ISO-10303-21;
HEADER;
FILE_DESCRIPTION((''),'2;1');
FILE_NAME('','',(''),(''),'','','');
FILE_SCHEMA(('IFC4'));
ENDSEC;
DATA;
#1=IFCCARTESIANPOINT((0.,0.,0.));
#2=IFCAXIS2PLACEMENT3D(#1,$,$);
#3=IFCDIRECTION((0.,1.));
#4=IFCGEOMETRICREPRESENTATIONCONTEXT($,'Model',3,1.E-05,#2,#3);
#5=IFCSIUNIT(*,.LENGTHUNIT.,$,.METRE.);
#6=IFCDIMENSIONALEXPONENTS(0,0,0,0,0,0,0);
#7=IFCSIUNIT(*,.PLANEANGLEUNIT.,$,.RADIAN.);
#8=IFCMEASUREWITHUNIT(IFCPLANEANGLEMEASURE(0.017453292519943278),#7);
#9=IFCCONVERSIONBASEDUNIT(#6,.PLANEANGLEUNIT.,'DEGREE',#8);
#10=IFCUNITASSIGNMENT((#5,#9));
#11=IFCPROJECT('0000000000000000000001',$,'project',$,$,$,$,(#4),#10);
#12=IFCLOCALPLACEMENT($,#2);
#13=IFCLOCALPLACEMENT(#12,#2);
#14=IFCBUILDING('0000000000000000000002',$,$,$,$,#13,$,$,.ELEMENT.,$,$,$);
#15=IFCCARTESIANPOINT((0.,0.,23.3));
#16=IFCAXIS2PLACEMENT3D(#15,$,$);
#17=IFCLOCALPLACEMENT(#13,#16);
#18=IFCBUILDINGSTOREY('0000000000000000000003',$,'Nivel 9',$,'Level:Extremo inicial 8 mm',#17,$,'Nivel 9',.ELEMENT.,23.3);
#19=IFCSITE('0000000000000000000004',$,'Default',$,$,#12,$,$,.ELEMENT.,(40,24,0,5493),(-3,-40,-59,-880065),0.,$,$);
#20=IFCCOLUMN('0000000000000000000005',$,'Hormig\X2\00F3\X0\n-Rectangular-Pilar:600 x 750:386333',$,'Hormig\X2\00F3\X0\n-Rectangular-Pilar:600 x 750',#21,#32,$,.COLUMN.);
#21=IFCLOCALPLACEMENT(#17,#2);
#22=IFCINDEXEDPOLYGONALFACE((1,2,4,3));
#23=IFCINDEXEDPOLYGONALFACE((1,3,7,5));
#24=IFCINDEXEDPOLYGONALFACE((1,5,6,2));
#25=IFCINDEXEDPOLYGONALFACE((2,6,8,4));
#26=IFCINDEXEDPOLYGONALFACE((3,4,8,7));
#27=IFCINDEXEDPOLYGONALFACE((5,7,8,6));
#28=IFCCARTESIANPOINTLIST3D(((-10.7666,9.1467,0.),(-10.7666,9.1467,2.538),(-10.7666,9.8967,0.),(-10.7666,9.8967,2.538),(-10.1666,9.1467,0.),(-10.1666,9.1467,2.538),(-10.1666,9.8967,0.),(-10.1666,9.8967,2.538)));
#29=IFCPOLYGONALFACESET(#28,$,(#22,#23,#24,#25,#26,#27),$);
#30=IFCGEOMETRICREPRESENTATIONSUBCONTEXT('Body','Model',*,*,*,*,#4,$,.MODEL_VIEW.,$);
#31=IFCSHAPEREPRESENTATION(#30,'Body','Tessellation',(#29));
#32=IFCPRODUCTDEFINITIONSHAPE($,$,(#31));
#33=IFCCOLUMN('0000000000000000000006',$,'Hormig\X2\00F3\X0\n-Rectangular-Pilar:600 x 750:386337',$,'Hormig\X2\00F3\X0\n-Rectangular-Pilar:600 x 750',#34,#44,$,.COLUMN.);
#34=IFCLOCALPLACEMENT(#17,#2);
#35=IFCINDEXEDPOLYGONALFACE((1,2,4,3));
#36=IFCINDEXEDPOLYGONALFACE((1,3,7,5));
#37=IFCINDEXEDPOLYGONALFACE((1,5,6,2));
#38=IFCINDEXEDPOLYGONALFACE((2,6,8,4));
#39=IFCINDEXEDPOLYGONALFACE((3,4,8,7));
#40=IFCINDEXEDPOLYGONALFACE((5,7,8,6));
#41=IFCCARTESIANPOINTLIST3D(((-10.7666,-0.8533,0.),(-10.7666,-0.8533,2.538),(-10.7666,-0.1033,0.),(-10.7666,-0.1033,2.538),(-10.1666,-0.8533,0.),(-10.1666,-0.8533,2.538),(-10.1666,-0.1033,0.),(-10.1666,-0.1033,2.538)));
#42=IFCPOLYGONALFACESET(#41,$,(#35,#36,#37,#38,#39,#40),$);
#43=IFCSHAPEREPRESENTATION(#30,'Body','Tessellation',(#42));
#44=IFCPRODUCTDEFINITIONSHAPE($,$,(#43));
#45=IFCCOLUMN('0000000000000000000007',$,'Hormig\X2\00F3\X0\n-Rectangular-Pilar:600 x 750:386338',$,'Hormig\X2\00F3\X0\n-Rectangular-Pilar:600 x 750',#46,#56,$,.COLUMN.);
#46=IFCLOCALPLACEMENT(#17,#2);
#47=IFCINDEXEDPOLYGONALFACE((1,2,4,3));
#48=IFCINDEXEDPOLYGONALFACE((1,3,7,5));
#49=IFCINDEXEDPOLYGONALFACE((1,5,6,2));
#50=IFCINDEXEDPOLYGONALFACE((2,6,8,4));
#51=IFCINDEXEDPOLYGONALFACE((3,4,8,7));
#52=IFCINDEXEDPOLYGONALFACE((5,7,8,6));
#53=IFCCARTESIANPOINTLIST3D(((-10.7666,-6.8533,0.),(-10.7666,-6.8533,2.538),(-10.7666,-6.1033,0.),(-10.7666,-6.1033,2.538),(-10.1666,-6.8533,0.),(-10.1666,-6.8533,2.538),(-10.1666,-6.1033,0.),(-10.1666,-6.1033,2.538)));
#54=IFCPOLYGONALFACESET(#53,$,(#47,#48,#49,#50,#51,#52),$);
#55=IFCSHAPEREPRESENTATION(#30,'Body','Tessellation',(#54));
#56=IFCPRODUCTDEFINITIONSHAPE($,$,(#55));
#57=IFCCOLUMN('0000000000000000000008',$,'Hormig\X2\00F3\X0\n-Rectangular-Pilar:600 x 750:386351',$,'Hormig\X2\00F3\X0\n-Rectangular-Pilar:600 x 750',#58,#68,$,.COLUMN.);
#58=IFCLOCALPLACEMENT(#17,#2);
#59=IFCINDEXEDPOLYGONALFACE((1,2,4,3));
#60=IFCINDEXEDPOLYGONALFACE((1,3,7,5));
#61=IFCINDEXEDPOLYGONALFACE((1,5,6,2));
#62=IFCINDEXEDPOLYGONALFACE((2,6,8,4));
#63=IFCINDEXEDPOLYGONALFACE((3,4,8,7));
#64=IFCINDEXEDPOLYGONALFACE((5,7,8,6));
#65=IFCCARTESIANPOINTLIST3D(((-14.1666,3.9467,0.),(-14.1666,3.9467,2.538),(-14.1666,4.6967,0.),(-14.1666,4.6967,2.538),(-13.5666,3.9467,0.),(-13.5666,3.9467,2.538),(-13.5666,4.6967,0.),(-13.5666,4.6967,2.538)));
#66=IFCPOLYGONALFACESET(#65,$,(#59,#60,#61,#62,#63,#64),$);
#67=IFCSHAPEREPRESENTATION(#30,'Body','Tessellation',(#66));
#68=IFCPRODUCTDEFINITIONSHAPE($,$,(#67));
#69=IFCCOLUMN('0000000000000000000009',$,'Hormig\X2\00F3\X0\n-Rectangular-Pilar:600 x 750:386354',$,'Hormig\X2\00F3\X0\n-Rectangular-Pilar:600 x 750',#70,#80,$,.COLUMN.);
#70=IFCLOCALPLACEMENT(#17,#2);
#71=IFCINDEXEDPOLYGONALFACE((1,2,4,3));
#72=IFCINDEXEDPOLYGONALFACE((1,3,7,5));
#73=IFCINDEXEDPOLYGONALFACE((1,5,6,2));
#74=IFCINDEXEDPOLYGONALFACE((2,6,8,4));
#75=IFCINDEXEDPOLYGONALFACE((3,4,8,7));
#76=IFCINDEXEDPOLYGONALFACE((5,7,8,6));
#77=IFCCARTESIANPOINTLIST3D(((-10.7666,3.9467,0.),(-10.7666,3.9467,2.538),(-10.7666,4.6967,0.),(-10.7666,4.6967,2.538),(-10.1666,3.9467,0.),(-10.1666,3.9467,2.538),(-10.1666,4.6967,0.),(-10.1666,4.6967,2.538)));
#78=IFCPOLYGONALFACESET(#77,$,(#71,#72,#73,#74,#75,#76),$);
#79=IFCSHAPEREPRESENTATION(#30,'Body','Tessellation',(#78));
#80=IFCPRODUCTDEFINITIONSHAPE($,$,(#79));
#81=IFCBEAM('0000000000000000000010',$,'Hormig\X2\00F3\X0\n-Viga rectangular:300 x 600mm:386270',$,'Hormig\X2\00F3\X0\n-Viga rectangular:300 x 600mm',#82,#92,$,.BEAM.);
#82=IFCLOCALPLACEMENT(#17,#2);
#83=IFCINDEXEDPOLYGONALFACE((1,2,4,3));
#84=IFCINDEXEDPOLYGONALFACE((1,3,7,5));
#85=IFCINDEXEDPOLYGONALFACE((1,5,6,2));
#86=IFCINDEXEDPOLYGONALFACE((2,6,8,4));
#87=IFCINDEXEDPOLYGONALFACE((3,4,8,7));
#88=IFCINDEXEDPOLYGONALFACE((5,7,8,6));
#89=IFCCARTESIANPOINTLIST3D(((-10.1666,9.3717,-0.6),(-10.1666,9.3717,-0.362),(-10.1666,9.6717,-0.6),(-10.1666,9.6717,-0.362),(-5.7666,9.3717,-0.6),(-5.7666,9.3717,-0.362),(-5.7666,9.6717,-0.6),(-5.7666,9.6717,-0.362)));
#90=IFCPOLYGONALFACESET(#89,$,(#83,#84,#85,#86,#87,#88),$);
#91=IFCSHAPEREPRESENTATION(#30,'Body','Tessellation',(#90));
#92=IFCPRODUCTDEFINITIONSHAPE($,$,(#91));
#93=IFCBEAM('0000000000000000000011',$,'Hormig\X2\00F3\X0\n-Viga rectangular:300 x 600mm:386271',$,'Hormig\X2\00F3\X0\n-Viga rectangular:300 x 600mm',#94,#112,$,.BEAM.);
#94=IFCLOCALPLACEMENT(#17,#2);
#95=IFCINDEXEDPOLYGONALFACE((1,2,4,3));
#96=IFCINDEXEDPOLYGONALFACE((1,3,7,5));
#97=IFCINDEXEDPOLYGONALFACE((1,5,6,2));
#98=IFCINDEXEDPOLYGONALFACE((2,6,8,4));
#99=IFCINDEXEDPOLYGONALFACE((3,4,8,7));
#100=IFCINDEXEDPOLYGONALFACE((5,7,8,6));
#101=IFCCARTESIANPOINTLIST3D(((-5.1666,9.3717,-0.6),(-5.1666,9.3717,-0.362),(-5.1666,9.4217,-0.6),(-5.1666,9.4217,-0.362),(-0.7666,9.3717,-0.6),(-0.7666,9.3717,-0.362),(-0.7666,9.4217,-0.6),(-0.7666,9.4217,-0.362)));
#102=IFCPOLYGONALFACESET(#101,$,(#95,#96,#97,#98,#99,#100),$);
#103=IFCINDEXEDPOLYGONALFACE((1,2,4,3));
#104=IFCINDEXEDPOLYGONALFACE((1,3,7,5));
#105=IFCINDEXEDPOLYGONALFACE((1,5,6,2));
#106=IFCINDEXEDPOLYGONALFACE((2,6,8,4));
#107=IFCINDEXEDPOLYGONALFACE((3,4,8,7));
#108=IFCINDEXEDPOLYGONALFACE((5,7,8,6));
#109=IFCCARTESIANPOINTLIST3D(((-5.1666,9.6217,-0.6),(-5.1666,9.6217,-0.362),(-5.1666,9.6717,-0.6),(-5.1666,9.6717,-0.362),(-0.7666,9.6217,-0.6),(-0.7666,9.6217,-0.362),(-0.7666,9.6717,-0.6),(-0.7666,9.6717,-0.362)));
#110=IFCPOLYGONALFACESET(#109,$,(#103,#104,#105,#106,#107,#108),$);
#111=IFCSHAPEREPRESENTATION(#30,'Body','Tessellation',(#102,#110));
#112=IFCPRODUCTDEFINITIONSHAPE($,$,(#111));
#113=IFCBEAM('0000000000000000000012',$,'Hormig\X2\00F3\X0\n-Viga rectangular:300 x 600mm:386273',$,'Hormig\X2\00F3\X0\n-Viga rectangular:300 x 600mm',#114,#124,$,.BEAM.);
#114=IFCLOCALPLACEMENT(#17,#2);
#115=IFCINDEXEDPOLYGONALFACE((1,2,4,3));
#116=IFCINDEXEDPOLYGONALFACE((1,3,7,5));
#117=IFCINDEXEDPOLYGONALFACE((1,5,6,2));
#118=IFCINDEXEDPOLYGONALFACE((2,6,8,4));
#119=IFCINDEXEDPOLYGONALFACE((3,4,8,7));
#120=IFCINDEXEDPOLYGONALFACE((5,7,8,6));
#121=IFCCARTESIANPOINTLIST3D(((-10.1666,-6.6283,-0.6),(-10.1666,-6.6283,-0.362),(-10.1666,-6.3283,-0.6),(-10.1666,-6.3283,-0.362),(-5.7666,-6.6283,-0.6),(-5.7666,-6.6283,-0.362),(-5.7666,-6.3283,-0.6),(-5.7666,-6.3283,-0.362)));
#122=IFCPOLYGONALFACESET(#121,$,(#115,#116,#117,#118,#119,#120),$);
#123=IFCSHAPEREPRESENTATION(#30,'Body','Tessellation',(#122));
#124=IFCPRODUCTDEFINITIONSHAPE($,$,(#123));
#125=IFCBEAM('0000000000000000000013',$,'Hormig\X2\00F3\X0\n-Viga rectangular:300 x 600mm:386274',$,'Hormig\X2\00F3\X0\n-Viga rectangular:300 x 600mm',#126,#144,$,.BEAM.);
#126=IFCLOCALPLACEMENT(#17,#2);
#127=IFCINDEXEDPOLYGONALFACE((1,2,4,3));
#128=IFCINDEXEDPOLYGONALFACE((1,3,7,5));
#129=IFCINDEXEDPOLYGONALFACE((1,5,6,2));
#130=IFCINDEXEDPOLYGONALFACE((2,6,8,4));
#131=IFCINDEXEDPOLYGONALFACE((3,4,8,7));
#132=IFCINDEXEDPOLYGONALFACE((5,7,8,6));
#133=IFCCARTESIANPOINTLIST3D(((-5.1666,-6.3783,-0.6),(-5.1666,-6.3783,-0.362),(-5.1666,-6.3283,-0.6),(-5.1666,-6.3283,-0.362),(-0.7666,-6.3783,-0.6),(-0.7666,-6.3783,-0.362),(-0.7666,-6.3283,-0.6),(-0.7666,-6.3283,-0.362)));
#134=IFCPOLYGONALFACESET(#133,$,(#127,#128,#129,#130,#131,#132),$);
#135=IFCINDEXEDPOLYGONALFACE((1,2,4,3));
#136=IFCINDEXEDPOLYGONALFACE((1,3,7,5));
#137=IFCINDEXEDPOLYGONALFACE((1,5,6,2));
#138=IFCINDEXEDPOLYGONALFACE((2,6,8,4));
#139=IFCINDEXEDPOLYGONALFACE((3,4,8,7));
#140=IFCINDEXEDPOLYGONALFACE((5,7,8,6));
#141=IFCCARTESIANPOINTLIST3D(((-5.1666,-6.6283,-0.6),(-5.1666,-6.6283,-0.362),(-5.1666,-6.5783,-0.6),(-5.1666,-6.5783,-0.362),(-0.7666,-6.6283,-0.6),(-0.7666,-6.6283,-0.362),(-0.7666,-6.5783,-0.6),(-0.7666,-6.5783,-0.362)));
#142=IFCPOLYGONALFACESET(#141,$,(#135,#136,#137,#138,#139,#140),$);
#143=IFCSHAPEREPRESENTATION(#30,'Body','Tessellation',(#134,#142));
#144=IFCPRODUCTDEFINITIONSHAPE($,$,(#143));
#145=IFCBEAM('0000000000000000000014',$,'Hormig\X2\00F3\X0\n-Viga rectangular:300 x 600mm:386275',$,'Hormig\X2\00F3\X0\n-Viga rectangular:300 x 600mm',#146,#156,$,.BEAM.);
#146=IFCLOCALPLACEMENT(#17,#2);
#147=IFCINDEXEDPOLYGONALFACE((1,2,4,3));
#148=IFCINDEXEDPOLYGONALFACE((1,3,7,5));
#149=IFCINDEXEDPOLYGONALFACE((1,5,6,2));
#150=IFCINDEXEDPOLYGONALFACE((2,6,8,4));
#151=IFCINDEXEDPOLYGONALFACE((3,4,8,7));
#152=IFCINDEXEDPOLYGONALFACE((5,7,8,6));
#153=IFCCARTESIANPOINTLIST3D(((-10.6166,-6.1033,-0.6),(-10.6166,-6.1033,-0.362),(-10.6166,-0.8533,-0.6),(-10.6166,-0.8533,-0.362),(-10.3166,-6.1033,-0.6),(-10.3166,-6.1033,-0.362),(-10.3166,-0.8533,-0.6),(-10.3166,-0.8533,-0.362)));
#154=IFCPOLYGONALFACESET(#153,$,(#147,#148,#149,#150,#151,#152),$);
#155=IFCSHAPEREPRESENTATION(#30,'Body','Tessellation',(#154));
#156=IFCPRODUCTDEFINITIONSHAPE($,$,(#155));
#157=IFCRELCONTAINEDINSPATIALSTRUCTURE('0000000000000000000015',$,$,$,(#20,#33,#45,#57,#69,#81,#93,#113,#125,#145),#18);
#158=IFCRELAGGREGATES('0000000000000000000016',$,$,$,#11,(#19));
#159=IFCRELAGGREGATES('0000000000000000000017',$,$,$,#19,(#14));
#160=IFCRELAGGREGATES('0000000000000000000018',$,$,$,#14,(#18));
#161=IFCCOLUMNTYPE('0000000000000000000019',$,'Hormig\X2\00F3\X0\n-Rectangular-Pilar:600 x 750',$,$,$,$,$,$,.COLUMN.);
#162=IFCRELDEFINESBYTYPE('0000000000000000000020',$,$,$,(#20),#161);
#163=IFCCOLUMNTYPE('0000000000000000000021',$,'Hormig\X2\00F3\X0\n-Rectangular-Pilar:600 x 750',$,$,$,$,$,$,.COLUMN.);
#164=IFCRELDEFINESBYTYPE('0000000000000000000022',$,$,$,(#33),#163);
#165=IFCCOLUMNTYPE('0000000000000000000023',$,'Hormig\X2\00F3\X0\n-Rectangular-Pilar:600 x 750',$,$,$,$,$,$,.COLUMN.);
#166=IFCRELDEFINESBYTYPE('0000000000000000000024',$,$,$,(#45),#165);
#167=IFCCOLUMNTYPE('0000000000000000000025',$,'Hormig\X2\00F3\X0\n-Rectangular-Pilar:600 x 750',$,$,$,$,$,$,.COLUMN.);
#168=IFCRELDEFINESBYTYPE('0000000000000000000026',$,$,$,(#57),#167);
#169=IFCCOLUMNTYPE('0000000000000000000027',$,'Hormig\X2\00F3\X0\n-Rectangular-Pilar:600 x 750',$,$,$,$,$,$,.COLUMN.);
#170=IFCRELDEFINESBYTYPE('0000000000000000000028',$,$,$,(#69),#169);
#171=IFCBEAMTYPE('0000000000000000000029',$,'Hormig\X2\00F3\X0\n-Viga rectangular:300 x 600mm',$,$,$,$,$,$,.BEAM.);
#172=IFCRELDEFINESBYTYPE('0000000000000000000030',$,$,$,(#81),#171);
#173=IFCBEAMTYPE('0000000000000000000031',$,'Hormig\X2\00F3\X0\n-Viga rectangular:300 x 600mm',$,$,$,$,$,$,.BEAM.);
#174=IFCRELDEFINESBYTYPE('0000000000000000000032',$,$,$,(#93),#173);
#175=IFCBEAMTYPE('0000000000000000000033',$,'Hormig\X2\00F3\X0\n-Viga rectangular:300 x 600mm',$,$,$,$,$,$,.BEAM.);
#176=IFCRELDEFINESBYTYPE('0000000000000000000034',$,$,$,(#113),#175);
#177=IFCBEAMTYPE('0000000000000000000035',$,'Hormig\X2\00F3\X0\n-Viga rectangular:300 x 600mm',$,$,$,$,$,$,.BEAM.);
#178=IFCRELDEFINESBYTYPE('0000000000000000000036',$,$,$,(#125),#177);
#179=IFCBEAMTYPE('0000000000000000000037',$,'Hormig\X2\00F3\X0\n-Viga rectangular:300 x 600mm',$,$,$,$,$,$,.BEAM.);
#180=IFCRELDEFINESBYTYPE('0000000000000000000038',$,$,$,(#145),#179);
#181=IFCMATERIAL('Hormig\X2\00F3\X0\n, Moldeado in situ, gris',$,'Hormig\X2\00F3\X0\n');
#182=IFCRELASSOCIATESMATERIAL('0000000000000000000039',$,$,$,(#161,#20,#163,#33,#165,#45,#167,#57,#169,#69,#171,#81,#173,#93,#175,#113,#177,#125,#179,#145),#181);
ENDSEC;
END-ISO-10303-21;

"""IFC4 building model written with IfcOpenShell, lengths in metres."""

from ifc_helpers import new_model, entity, si_unit, converted_unit, direction, frame, origin, place, context, subcontext, project, spatial, indexed_curve, outline, extrude, source, transform, mapped, material, type_object, type_shapes, element, save


model = new_model("IFC4")

# Units and contexts
model_context = context("Model", 3, precision=1e-05, world=origin(), true_north=direction((0.0, 1.0)))
body_context = subcontext(model_context, "Body", "Model", "MODEL_VIEW")
ifc_project = project(units=[si_unit("LENGTHUNIT", "METRE"), converted_unit("PLANEANGLEUNIT", "DEGREE", entity("IfcPlaneAngleMeasure", 0.017453292519943278), si_unit("PLANEANGLEUNIT", "RADIAN"), dimensions=[0, 0, 0, 0, 0, 0, 0])], contexts=[model_context])

# Site, building, storey
site_placement = place(None, origin())
site = spatial("IfcSite", under=ifc_project, at=site_placement, Name="Default", CompositionType="ELEMENT", RefLatitude=(40, 24, 0, 5493), RefLongitude=(-3, -40, -59, -880065), RefElevation=0.0)
building_placement = place(site_placement, origin())
building = spatial("IfcBuilding", under=site, at=building_placement, CompositionType="ELEMENT")
storey_placement = place(building_placement, frame((0.0, 0.0, 23.3)))
storey = spatial("IfcBuildingStorey", under=building, at=storey_placement, Name="Nivel 9", ObjectType="Level:Extremo inicial 8 mm", LongName="Nivel 9", CompositionType="ELEMENT", Elevation=23.3)

# Columns
ifc_material_1 = material(Name="Hormigón, Moldeado in situ, gris", Category="Hormigón")
column_type_1 = type_object("IfcColumnType", Name="Hormigón-Rectangular-Pilar:600 x 750", PredefinedType="COLUMN", material=ifc_material_1)
shared_shape_1 = source(origin(), body_context, "Body", "SweptSolid", [
    extrude(outline(indexed_curve([(-0.3, -0.375), (0.3, -0.375), (0.3, 0.375), (-0.3, 0.375), (-0.3, -0.375)], self_intersect=False)), frame((-10.4666, 9.5217, 23.3), z_axis=(0.0, 0.0, 1.0), x_axis=(-1.0, 0.0, 0.0)), (0.0, 0.0, 1.0), 2.538),
])
type_shapes(column_type_1, [shared_shape_1])
column_1_placement = place(storey_placement, frame((0.0, 0.0, -23.3)))
element("IfcColumn", 1, at=column_1_placement, inside=storey, type_object=column_type_1, material=ifc_material_1, Name="Hormigón-Rectangular-Pilar:600 x 750:386333", ObjectType="Hormigón-Rectangular-Pilar:600 x 750", PredefinedType="COLUMN", context=body_context, shape_type="MappedRepresentation", body=[
    mapped(shared_shape_1, transform((0.0, 0.0, 0.0), scale=1.0)),
])
column_type_2 = type_object("IfcColumnType", Name="Hormigón-Rectangular-Pilar:600 x 750", PredefinedType="COLUMN", material=ifc_material_1)
shared_shape_2 = source(origin(), body_context, "Body", "SweptSolid", [
    extrude(outline(indexed_curve([(-0.3, -0.375), (0.3, -0.375), (0.3, 0.375), (-0.3, 0.375), (-0.3, -0.375)], self_intersect=False)), frame((-10.4666, -0.4783, 23.3), z_axis=(0.0, 0.0, 1.0), x_axis=(-1.0, 0.0, 0.0)), (0.0, 0.0, 1.0), 2.538),
])
type_shapes(column_type_2, [shared_shape_2])
column_2_placement = place(storey_placement, frame((0.0, 0.0, -23.3)))
element("IfcColumn", 2, at=column_2_placement, inside=storey, type_object=column_type_2, material=ifc_material_1, Name="Hormigón-Rectangular-Pilar:600 x 750:386337", ObjectType="Hormigón-Rectangular-Pilar:600 x 750", PredefinedType="COLUMN", context=body_context, shape_type="MappedRepresentation", body=[
    mapped(shared_shape_2, transform((0.0, 0.0, 0.0), scale=1.0)),
])
column_type_3 = type_object("IfcColumnType", Name="Hormigón-Rectangular-Pilar:600 x 750", PredefinedType="COLUMN", material=ifc_material_1)
shared_shape_3 = source(origin(), body_context, "Body", "SweptSolid", [
    extrude(outline(indexed_curve([(-0.3, -0.375), (0.3, -0.375), (0.3, 0.375), (-0.3, 0.375), (-0.3, -0.375)], self_intersect=False)), frame((-10.4666, -6.4783, 23.3), z_axis=(0.0, 0.0, 1.0), x_axis=(-1.0, 0.0, 0.0)), (0.0, 0.0, 1.0), 2.538),
])
type_shapes(column_type_3, [shared_shape_3])
column_3_placement = place(storey_placement, frame((0.0, 0.0, -23.3)))
element("IfcColumn", 3, at=column_3_placement, inside=storey, type_object=column_type_3, material=ifc_material_1, Name="Hormigón-Rectangular-Pilar:600 x 750:386338", ObjectType="Hormigón-Rectangular-Pilar:600 x 750", PredefinedType="COLUMN", context=body_context, shape_type="MappedRepresentation", body=[
    mapped(shared_shape_3, transform((0.0, 0.0, 0.0), scale=1.0)),
])
column_type_4 = type_object("IfcColumnType", Name="Hormigón-Rectangular-Pilar:600 x 750", PredefinedType="COLUMN", material=ifc_material_1)
shared_shape_4 = source(origin(), body_context, "Body", "SweptSolid", [
    extrude(outline(indexed_curve([(-0.3, -0.375), (0.3, -0.375), (0.3, 0.375), (-0.3, 0.375), (-0.3, -0.375)], self_intersect=False)), frame((-13.8666, 4.3217, 23.3), z_axis=(0.0, 0.0, 1.0), x_axis=(-1.0, 0.0, 0.0)), (0.0, 0.0, 1.0), 2.538),
])
type_shapes(column_type_4, [shared_shape_4])
column_4_placement = place(storey_placement, frame((0.0, 0.0, -23.3)))
element("IfcColumn", 4, at=column_4_placement, inside=storey, type_object=column_type_4, material=ifc_material_1, Name="Hormigón-Rectangular-Pilar:600 x 750:386351", ObjectType="Hormigón-Rectangular-Pilar:600 x 750", PredefinedType="COLUMN", context=body_context, shape_type="MappedRepresentation", body=[
    mapped(shared_shape_4, transform((0.0, 0.0, 0.0), scale=1.0)),
])
column_type_5 = type_object("IfcColumnType", Name="Hormigón-Rectangular-Pilar:600 x 750", PredefinedType="COLUMN", material=ifc_material_1)
shared_shape_5 = source(origin(), body_context, "Body", "SweptSolid", [
    extrude(outline(indexed_curve([(-0.3, -0.375), (0.3, -0.375), (0.3, 0.375), (-0.3, 0.375), (-0.3, -0.375)], self_intersect=False)), frame((-10.4666, 4.3217, 23.3), z_axis=(0.0, 0.0, 1.0), x_axis=(-1.0, 0.0, 0.0)), (0.0, 0.0, 1.0), 2.538),
])
type_shapes(column_type_5, [shared_shape_5])
column_5_placement = place(storey_placement, frame((0.0, 0.0, -23.3)))
element("IfcColumn", 5, at=column_5_placement, inside=storey, type_object=column_type_5, material=ifc_material_1, Name="Hormigón-Rectangular-Pilar:600 x 750:386354", ObjectType="Hormigón-Rectangular-Pilar:600 x 750", PredefinedType="COLUMN", context=body_context, shape_type="MappedRepresentation", body=[
    mapped(shared_shape_5, transform((0.0, 0.0, 0.0), scale=1.0)),
])

# Beams
beam_type_1 = type_object("IfcBeamType", Name="Hormigón-Viga rectangular:300 x 600mm", PredefinedType="BEAM", material=ifc_material_1)
shared_shape_6 = source(origin(), body_context, "Body", "SweptSolid", [
    extrude(outline(indexed_curve([(-0.119, -0.15), (0.119, -0.15), (0.119, 0.15), (-0.119, 0.15), (-0.119, -0.15)], self_intersect=False)), frame((-5.7666, 9.5217, 22.819), z_axis=(-1.0, 0.0, 0.0), x_axis=(0.0, 0.0, -1.0)), (0.0, 0.0, 1.0), 4.4),
])
type_shapes(beam_type_1, [shared_shape_6])
beam_1_placement = place(storey_placement, frame((0.0, 0.0, -23.3)))
element("IfcBeam", 6, at=beam_1_placement, inside=storey, type_object=beam_type_1, material=ifc_material_1, Name="Hormigón-Viga rectangular:300 x 600mm:386270", ObjectType="Hormigón-Viga rectangular:300 x 600mm", PredefinedType="BEAM", context=body_context, shape_type="MappedRepresentation", body=[
    mapped(shared_shape_6, transform((0.0, 0.0, 0.0), scale=1.0)),
])
beam_type_2 = type_object("IfcBeamType", Name="Hormigón-Viga rectangular:300 x 600mm", PredefinedType="BEAM", material=ifc_material_1)
shared_shape_7 = source(origin(), body_context, "Body", "SweptSolid", [
    extrude(outline(indexed_curve([(-0.119, -0.025), (0.119, -0.025), (0.119, 0.025), (-0.119, 0.025), (-0.119, -0.025)], self_intersect=False)), frame((-5.1666, 9.3967, 22.819), z_axis=(1.0, 0.0, 0.0), x_axis=(0.0, 0.0, -1.0)), (0.0, 0.0, 1.0), 4.4),
    extrude(outline(indexed_curve([(-0.119, -0.025), (0.119, -0.025), (0.119, 0.025), (-0.119, 0.025), (-0.119, -0.025)], self_intersect=False)), frame((-5.1666, 9.6467, 22.819), z_axis=(1.0, 0.0, 0.0), x_axis=(0.0, 0.0, -1.0)), (0.0, 0.0, 1.0), 4.4),
])
type_shapes(beam_type_2, [shared_shape_7])
beam_2_placement = place(storey_placement, frame((0.0, 0.0, -23.3)))
element("IfcBeam", 7, at=beam_2_placement, inside=storey, type_object=beam_type_2, material=ifc_material_1, Name="Hormigón-Viga rectangular:300 x 600mm:386271", ObjectType="Hormigón-Viga rectangular:300 x 600mm", PredefinedType="BEAM", context=body_context, shape_type="MappedRepresentation", body=[
    mapped(shared_shape_7, transform((0.0, 0.0, 0.0), scale=1.0)),
])
beam_type_3 = type_object("IfcBeamType", Name="Hormigón-Viga rectangular:300 x 600mm", PredefinedType="BEAM", material=ifc_material_1)
shared_shape_8 = source(origin(), body_context, "Body", "SweptSolid", [
    extrude(outline(indexed_curve([(-0.119, -0.15), (0.119, -0.15), (0.119, 0.15), (-0.119, 0.15), (-0.119, -0.15)], self_intersect=False)), frame((-10.1666, -6.4783, 22.819), z_axis=(1.0, 0.0, 0.0), x_axis=(0.0, 0.0, -1.0)), (0.0, 0.0, 1.0), 4.4),
])
type_shapes(beam_type_3, [shared_shape_8])
beam_3_placement = place(storey_placement, frame((0.0, 0.0, -23.3)))
element("IfcBeam", 8, at=beam_3_placement, inside=storey, type_object=beam_type_3, material=ifc_material_1, Name="Hormigón-Viga rectangular:300 x 600mm:386273", ObjectType="Hormigón-Viga rectangular:300 x 600mm", PredefinedType="BEAM", context=body_context, shape_type="MappedRepresentation", body=[
    mapped(shared_shape_8, transform((0.0, 0.0, 0.0), scale=1.0)),
])
beam_type_4 = type_object("IfcBeamType", Name="Hormigón-Viga rectangular:300 x 600mm", PredefinedType="BEAM", material=ifc_material_1)
shared_shape_9 = source(origin(), body_context, "Body", "SweptSolid", [
    extrude(outline(indexed_curve([(-0.119, -0.025), (0.119, -0.025), (0.119, 0.025), (-0.119, 0.025), (-0.119, -0.025)], self_intersect=False)), frame((-0.7666, -6.3533, 22.819), z_axis=(-1.0, 0.0, 0.0), x_axis=(0.0, 0.0, -1.0)), (0.0, 0.0, 1.0), 4.4),
    extrude(outline(indexed_curve([(-0.119, -0.025), (0.119, -0.025), (0.119, 0.025), (-0.119, 0.025), (-0.119, -0.025)], self_intersect=False)), frame((-0.7666, -6.6033, 22.819), z_axis=(-1.0, 0.0, 0.0), x_axis=(0.0, 0.0, -1.0)), (0.0, 0.0, 1.0), 4.4),
])
type_shapes(beam_type_4, [shared_shape_9])
beam_4_placement = place(storey_placement, frame((0.0, 0.0, -23.3)))
element("IfcBeam", 9, at=beam_4_placement, inside=storey, type_object=beam_type_4, material=ifc_material_1, Name="Hormigón-Viga rectangular:300 x 600mm:386274", ObjectType="Hormigón-Viga rectangular:300 x 600mm", PredefinedType="BEAM", context=body_context, shape_type="MappedRepresentation", body=[
    mapped(shared_shape_9, transform((0.0, 0.0, 0.0), scale=1.0)),
])
beam_type_5 = type_object("IfcBeamType", Name="Hormigón-Viga rectangular:300 x 600mm", PredefinedType="BEAM", material=ifc_material_1)
shared_shape_10 = source(origin(), body_context, "Body", "SweptSolid", [
    extrude(outline(indexed_curve([(-0.15, -0.119), (0.15, -0.119), (0.15, 0.119), (-0.15, 0.119), (-0.15, -0.119)], self_intersect=False)), frame((-10.4666, -6.1033, 22.819), z_axis=(0.0, 1.0, 0.0), x_axis=(-1.0, 0.0, 0.0)), (0.0, 0.0, 1.0), 5.25),
])
type_shapes(beam_type_5, [shared_shape_10])
beam_5_placement = place(storey_placement, frame((0.0, 0.0, -23.3)))
element("IfcBeam", 10, at=beam_5_placement, inside=storey, type_object=beam_type_5, material=ifc_material_1, Name="Hormigón-Viga rectangular:300 x 600mm:386275", ObjectType="Hormigón-Viga rectangular:300 x 600mm", PredefinedType="BEAM", context=body_context, shape_type="MappedRepresentation", body=[
    mapped(shared_shape_10, transform((0.0, 0.0, 0.0), scale=1.0)),
])

save(model, "model.ifc")
